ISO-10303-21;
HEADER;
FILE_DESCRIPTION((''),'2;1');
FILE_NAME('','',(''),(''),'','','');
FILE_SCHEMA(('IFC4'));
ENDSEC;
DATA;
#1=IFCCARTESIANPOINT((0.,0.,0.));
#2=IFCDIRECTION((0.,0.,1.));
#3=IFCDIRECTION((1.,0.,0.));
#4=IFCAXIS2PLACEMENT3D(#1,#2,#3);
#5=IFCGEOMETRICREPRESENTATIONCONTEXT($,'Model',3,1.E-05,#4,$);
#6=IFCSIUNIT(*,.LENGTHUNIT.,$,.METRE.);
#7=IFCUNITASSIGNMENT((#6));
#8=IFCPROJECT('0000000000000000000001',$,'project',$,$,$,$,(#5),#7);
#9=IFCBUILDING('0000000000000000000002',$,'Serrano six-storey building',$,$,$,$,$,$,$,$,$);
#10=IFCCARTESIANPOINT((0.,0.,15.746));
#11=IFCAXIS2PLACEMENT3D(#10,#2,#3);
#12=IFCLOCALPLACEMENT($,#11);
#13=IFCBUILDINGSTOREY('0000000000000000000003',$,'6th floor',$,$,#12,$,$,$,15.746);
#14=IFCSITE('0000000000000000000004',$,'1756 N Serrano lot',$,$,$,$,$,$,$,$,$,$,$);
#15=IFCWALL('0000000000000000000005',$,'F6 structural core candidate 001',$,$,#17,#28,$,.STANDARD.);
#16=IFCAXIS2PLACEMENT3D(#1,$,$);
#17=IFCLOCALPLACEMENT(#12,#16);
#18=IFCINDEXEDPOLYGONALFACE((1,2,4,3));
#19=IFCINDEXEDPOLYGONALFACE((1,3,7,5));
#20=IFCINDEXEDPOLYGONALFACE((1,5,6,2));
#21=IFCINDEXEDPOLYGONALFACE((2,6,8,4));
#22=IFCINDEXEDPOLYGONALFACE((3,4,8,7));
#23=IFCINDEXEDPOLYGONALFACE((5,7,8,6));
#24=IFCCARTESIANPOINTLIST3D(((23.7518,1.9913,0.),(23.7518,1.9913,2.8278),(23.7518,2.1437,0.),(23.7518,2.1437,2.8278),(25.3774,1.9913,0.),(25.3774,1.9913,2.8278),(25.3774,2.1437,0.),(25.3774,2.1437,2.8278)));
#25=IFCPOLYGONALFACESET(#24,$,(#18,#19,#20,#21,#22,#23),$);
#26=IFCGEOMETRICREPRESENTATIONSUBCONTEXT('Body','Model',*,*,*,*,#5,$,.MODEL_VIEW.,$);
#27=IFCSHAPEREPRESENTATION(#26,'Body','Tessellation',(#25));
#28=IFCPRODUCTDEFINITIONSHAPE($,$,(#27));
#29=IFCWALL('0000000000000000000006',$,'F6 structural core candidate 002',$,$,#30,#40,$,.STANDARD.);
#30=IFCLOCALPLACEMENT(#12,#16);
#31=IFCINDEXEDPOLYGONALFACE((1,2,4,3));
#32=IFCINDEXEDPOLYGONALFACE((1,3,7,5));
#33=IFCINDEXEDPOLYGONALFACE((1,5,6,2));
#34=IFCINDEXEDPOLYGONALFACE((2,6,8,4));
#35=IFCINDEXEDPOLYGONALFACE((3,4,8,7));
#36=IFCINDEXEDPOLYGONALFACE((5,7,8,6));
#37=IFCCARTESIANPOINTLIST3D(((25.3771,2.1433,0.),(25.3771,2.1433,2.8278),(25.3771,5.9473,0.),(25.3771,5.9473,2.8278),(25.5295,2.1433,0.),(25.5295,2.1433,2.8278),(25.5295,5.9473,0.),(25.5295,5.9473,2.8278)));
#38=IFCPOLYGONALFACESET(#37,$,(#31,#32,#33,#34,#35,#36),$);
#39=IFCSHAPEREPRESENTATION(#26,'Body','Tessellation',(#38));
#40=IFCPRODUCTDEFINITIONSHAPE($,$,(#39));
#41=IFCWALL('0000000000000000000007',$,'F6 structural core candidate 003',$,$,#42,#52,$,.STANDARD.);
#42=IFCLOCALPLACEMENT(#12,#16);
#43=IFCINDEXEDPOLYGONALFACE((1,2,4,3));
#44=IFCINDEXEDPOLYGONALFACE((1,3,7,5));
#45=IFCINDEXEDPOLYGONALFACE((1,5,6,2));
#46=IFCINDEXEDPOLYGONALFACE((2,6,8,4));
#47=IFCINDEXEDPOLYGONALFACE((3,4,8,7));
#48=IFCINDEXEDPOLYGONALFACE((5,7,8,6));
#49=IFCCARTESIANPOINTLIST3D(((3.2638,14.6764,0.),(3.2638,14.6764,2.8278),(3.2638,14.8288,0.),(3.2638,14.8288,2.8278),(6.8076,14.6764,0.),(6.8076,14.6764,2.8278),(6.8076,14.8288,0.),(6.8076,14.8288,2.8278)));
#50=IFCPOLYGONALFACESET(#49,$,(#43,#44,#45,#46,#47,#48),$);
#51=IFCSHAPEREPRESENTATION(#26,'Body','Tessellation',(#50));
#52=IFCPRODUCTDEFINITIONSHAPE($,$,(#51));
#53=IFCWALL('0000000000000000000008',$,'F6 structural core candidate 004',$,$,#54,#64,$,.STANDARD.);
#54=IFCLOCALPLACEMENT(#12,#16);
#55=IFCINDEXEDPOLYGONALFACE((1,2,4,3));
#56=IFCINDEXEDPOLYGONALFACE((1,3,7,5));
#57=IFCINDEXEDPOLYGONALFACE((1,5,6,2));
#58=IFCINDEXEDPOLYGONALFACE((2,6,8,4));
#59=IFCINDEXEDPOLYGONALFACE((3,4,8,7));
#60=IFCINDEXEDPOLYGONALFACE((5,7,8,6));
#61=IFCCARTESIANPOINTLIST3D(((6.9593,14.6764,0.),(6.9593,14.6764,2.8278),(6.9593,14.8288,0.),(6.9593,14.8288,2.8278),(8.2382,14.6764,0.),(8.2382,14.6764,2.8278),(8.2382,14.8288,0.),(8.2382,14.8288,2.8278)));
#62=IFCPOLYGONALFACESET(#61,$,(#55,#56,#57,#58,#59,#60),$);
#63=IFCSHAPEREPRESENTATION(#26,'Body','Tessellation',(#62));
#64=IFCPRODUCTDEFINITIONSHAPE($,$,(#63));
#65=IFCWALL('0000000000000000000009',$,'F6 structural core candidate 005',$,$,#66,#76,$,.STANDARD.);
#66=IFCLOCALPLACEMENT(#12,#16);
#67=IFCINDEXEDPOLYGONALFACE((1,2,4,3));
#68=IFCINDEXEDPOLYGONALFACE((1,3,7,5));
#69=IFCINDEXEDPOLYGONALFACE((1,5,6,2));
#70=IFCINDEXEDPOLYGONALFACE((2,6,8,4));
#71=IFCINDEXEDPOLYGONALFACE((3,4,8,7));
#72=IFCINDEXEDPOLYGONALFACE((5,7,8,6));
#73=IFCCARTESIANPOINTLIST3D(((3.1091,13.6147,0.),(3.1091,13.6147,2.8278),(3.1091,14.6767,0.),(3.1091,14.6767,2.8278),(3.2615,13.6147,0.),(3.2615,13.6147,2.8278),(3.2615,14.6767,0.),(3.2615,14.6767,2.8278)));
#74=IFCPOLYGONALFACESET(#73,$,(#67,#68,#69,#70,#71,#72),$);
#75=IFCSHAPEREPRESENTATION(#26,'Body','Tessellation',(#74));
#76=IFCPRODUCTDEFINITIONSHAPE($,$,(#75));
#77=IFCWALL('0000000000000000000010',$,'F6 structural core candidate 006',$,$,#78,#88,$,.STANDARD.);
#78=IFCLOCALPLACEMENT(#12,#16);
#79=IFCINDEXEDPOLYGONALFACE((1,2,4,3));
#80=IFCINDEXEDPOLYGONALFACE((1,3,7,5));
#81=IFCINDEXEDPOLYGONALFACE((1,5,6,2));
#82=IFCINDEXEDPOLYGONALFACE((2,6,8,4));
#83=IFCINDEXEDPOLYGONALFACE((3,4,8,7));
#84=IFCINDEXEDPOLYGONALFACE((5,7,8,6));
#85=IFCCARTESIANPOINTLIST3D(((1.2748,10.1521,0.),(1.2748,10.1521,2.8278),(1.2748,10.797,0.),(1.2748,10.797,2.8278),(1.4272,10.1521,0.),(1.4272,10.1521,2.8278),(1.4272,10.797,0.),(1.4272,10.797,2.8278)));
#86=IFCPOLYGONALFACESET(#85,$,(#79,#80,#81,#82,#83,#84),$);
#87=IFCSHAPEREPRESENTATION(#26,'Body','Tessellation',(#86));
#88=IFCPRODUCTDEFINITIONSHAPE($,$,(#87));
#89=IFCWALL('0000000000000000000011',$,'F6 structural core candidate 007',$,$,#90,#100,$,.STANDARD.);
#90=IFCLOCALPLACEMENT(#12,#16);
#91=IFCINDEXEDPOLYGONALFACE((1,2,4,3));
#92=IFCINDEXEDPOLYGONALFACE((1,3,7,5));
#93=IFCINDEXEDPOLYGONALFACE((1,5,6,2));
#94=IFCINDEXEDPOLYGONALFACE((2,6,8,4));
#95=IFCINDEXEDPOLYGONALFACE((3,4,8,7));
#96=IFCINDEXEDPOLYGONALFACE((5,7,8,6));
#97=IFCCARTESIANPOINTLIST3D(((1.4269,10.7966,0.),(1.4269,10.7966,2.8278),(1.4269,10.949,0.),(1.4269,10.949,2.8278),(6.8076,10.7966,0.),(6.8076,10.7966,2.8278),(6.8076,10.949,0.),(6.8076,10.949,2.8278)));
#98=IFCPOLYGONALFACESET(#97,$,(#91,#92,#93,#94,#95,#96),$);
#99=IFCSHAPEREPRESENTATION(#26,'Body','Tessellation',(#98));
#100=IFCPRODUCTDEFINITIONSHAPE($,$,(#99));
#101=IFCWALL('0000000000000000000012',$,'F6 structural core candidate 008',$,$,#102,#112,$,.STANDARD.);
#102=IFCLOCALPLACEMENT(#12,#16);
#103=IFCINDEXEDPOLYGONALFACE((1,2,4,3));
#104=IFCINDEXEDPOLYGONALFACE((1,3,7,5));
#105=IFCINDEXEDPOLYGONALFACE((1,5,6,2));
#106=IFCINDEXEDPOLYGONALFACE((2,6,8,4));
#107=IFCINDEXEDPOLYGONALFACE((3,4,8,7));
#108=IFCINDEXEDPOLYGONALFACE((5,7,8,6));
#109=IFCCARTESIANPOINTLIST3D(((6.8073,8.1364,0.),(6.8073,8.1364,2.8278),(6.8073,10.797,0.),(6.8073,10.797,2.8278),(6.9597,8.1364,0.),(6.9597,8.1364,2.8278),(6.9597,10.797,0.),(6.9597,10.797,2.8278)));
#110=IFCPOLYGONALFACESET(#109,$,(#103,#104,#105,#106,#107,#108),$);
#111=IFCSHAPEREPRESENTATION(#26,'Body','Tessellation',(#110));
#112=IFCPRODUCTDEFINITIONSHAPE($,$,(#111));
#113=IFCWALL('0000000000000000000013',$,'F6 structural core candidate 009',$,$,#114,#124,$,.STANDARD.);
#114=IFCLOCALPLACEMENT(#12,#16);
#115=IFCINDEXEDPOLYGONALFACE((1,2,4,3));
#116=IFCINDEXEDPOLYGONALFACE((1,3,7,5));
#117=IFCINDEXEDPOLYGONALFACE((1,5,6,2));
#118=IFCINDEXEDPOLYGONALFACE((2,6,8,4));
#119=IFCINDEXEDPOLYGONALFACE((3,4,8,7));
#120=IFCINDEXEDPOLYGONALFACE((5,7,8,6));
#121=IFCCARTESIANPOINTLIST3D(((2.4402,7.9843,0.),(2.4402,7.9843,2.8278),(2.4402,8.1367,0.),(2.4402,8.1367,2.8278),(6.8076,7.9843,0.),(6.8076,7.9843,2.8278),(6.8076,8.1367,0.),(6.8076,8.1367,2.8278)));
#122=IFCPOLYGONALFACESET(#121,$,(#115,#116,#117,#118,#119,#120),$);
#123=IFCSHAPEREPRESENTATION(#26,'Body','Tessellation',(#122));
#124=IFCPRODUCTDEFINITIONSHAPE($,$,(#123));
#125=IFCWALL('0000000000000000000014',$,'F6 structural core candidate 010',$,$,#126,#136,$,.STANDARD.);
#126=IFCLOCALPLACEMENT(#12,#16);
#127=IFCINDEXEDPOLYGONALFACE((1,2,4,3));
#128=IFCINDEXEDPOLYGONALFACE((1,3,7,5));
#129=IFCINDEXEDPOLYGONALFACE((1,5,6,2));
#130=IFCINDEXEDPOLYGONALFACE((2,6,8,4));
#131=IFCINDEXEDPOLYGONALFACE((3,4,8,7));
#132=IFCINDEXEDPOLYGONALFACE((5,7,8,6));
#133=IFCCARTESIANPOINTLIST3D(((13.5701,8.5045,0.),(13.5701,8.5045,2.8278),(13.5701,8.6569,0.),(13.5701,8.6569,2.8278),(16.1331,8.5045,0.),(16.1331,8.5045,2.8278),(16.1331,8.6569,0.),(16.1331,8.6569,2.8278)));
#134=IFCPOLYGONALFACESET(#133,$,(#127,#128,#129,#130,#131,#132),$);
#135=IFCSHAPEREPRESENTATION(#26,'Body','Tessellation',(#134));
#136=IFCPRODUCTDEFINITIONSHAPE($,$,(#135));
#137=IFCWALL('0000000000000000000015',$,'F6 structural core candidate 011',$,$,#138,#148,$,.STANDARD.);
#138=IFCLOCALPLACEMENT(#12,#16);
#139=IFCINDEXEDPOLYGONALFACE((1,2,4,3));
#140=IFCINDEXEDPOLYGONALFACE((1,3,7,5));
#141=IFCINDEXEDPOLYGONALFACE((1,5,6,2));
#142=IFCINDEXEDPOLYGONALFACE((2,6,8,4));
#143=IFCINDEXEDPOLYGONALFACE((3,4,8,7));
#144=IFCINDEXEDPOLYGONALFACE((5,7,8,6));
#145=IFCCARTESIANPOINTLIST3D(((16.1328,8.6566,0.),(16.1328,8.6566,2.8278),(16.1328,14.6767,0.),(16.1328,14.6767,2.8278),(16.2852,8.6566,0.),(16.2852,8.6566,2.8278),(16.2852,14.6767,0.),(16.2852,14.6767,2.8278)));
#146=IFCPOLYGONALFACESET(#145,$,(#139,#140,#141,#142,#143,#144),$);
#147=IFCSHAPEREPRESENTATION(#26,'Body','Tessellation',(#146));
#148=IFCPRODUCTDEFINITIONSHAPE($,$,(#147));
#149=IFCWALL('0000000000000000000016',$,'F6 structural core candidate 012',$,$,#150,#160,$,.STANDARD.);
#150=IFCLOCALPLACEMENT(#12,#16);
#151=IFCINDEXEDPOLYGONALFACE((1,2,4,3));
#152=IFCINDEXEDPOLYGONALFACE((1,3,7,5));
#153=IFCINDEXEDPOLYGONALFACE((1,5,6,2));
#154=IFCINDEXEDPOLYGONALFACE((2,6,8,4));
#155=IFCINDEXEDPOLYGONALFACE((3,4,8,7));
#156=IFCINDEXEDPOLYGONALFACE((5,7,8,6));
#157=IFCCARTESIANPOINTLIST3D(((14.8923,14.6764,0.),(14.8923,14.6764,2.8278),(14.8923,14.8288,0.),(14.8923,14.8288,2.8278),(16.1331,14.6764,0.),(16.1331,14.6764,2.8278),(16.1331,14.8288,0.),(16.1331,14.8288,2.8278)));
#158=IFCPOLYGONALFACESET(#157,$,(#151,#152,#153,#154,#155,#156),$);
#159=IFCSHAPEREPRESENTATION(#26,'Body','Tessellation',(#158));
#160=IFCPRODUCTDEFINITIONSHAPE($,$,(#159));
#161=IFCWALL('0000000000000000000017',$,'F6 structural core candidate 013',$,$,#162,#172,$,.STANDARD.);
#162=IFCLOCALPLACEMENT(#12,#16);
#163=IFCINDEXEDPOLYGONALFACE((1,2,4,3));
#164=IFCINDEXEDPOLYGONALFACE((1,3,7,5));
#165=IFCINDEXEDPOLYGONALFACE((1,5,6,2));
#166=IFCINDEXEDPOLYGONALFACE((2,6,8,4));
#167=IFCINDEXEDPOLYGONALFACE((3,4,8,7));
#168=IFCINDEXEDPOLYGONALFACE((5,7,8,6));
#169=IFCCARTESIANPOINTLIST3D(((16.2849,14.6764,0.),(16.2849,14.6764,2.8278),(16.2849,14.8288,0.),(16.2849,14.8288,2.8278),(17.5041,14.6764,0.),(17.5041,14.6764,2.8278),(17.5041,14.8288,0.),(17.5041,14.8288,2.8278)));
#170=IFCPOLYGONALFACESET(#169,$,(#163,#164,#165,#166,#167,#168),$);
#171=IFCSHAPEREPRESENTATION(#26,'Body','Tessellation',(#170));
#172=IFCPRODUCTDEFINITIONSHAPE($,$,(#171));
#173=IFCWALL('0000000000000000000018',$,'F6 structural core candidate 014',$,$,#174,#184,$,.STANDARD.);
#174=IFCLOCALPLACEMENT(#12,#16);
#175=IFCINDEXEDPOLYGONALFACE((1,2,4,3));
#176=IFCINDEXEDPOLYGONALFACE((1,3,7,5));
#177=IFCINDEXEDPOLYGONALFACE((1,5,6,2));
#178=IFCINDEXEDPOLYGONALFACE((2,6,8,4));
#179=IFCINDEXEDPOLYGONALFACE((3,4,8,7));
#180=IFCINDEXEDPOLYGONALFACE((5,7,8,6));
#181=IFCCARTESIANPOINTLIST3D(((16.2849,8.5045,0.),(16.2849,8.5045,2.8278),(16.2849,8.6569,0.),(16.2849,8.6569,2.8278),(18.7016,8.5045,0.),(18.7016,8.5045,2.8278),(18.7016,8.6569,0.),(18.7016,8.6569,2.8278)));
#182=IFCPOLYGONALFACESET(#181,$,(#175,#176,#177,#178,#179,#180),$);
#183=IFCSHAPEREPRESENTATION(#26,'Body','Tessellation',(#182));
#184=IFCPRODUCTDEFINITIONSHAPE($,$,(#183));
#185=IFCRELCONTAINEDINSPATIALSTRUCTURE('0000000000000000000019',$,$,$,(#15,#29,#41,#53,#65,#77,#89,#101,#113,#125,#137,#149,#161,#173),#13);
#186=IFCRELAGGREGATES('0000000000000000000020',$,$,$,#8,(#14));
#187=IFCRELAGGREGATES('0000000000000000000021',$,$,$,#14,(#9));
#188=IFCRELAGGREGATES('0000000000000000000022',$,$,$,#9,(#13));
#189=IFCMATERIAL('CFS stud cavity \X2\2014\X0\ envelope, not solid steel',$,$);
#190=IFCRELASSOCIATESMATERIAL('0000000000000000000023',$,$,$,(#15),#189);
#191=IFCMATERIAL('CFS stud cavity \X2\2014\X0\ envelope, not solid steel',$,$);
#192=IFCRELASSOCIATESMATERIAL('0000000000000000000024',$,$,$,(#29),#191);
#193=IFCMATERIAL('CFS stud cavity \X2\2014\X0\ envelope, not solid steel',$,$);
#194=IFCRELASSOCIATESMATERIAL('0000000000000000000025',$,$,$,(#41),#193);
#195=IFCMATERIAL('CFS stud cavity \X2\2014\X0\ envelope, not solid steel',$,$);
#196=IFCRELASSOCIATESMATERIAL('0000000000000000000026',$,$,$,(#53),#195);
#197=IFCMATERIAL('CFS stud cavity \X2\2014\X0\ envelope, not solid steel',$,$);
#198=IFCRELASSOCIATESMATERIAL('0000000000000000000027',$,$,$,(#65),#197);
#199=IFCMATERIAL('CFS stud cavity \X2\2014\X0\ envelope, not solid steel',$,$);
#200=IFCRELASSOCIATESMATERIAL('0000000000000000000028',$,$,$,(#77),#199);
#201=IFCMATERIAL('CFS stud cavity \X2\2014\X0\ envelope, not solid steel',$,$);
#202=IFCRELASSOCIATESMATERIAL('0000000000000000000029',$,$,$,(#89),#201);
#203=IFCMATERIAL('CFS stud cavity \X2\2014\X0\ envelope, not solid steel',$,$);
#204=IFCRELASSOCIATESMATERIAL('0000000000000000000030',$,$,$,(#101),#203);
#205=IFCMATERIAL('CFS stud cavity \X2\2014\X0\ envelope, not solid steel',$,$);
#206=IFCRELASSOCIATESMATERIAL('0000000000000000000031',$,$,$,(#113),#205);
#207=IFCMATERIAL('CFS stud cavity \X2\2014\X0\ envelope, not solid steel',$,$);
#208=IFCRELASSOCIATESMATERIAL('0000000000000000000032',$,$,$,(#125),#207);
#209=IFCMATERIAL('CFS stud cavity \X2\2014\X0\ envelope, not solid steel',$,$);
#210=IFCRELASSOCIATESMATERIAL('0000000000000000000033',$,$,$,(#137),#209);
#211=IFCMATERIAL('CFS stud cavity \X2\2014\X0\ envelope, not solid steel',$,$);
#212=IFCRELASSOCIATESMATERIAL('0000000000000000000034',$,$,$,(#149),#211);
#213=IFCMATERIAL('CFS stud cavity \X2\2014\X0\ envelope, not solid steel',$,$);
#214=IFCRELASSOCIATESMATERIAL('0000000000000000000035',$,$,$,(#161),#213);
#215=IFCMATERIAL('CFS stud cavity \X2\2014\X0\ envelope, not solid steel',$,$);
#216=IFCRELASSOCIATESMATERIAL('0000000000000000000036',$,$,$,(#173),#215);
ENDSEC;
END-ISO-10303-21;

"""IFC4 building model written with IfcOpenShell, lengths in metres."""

from ifc_helpers import new_model, si_unit, frame, origin_with_axes, place, context, subcontext, project, spatial, polyline, outline, extrude, material, element, save


model = new_model("IFC4")

# Units and contexts
model_context = context("Model", 3, precision=1e-05, world=origin_with_axes())
body_context = subcontext(model_context, "Body", "Model", "MODEL_VIEW")
ifc_project = project(units=[si_unit("LENGTHUNIT", "METRE")], contexts=[model_context])

# Site, building, storey
site = spatial("IfcSite", under=ifc_project, Name="1756 N Serrano lot")
building = spatial("IfcBuilding", under=site, Name="Serrano six-storey building")
storey_placement = place(None, frame((0.0, 0.0, 15.746), z_axis=(0.0, 0.0, 1.0), x_axis=(1.0, 0.0, 0.0)))
storey = spatial("IfcBuildingStorey", under=building, at=storey_placement, Name="6th floor", Elevation=15.746)

# Walls
ifc_material_1 = material(Name="CFS stud cavity — envelope, not solid steel")
wall_1_placement = place(storey_placement, frame((0.0, 0.0, -15.746), z_axis=(0.0, 0.0, 1.0), x_axis=(1.0, 0.0, 0.0)))
element("IfcWall", 1, at=wall_1_placement, inside=storey, material=ifc_material_1, Name="F6 structural core candidate 001", PredefinedType="STANDARD", context=body_context, shape_type="SweptSolid", body=[
    extrude(outline(polyline([(25.3774, 2.1437), (25.3774, 1.9913), (23.7518, 1.9913), (23.7518, 2.1437), (25.3774, 2.1437)])), frame((0.0, 0.0, 15.746)), (0.0, 0.0, 1.0), 2.8278),
])
ifc_material_2 = material(Name="CFS stud cavity — envelope, not solid steel")
wall_2_placement = place(storey_placement, frame((0.0, 0.0, -15.746), z_axis=(0.0, 0.0, 1.0), x_axis=(1.0, 0.0, 0.0)))
element("IfcWall", 2, at=wall_2_placement, inside=storey, material=ifc_material_2, Name="F6 structural core candidate 002", PredefinedType="STANDARD", context=body_context, shape_type="SweptSolid", body=[
    extrude(outline(polyline([(25.5295, 2.1433), (25.3771, 2.1433), (25.3771, 5.9473), (25.5295, 5.9473), (25.5295, 2.1433)])), frame((0.0, 0.0, 15.746)), (0.0, 0.0, 1.0), 2.8278),
])
ifc_material_3 = material(Name="CFS stud cavity — envelope, not solid steel")
wall_3_placement = place(storey_placement, frame((0.0, 0.0, -15.746), z_axis=(0.0, 0.0, 1.0), x_axis=(1.0, 0.0, 0.0)))
element("IfcWall", 3, at=wall_3_placement, inside=storey, material=ifc_material_3, Name="F6 structural core candidate 003", PredefinedType="STANDARD", context=body_context, shape_type="SweptSolid", body=[
    extrude(outline(polyline([(6.8076, 14.8288), (6.8076, 14.6764), (3.2638, 14.6764), (3.2638, 14.8288), (6.8076, 14.8288)])), frame((0.0, 0.0, 15.746)), (0.0, 0.0, 1.0), 2.8278),
])
ifc_material_4 = material(Name="CFS stud cavity — envelope, not solid steel")
wall_4_placement = place(storey_placement, frame((0.0, 0.0, -15.746), z_axis=(0.0, 0.0, 1.0), x_axis=(1.0, 0.0, 0.0)))
element("IfcWall", 4, at=wall_4_placement, inside=storey, material=ifc_material_4, Name="F6 structural core candidate 004", PredefinedType="STANDARD", context=body_context, shape_type="SweptSolid", body=[
    extrude(outline(polyline([(8.2382, 14.8288), (8.2382, 14.6764), (6.9593, 14.6764), (6.9593, 14.8288), (8.2382, 14.8288)])), frame((0.0, 0.0, 15.746)), (0.0, 0.0, 1.0), 2.8278),
])
ifc_material_5 = material(Name="CFS stud cavity — envelope, not solid steel")
wall_5_placement = place(storey_placement, frame((0.0, 0.0, -15.746), z_axis=(0.0, 0.0, 1.0), x_axis=(1.0, 0.0, 0.0)))
element("IfcWall", 5, at=wall_5_placement, inside=storey, material=ifc_material_5, Name="F6 structural core candidate 005", PredefinedType="STANDARD", context=body_context, shape_type="SweptSolid", body=[
    extrude(outline(polyline([(3.2615, 13.6147), (3.1091, 13.6147), (3.1091, 14.6767), (3.2615, 14.6767), (3.2615, 13.6147)])), frame((0.0, 0.0, 15.746)), (0.0, 0.0, 1.0), 2.8278),
])
ifc_material_6 = material(Name="CFS stud cavity — envelope, not solid steel")
wall_6_placement = place(storey_placement, frame((0.0, 0.0, -15.746), z_axis=(0.0, 0.0, 1.0), x_axis=(1.0, 0.0, 0.0)))
element("IfcWall", 6, at=wall_6_placement, inside=storey, material=ifc_material_6, Name="F6 structural core candidate 006", PredefinedType="STANDARD", context=body_context, shape_type="SweptSolid", body=[
    extrude(outline(polyline([(1.4272, 10.1521), (1.2748, 10.1521), (1.2748, 10.797), (1.4272, 10.797), (1.4272, 10.1521)])), frame((0.0, 0.0, 15.746)), (0.0, 0.0, 1.0), 2.8278),
])
ifc_material_7 = material(Name="CFS stud cavity — envelope, not solid steel")
wall_7_placement = place(storey_placement, frame((0.0, 0.0, -15.746), z_axis=(0.0, 0.0, 1.0), x_axis=(1.0, 0.0, 0.0)))
element("IfcWall", 7, at=wall_7_placement, inside=storey, material=ifc_material_7, Name="F6 structural core candidate 007", PredefinedType="STANDARD", context=body_context, shape_type="SweptSolid", body=[
    extrude(outline(polyline([(6.8076, 10.949), (6.8076, 10.7966), (1.4269, 10.7966), (1.4269, 10.949), (6.8076, 10.949)])), frame((0.0, 0.0, 15.746)), (0.0, 0.0, 1.0), 2.8278),
])
ifc_material_8 = material(Name="CFS stud cavity — envelope, not solid steel")
wall_8_placement = place(storey_placement, frame((0.0, 0.0, -15.746), z_axis=(0.0, 0.0, 1.0), x_axis=(1.0, 0.0, 0.0)))
element("IfcWall", 8, at=wall_8_placement, inside=storey, material=ifc_material_8, Name="F6 structural core candidate 008", PredefinedType="STANDARD", context=body_context, shape_type="SweptSolid", body=[
    extrude(outline(polyline([(6.9597, 8.1364), (6.8073, 8.1364), (6.8073, 10.797), (6.9597, 10.797), (6.9597, 8.1364)])), frame((0.0, 0.0, 15.746)), (0.0, 0.0, 1.0), 2.8278),
])
ifc_material_9 = material(Name="CFS stud cavity — envelope, not solid steel")
wall_9_placement = place(storey_placement, frame((0.0, 0.0, -15.746), z_axis=(0.0, 0.0, 1.0), x_axis=(1.0, 0.0, 0.0)))
element("IfcWall", 9, at=wall_9_placement, inside=storey, material=ifc_material_9, Name="F6 structural core candidate 009", PredefinedType="STANDARD", context=body_context, shape_type="SweptSolid", body=[
    extrude(outline(polyline([(6.8076, 8.1367), (6.8076, 7.9843), (2.4402, 7.9843), (2.4402, 8.1367), (6.8076, 8.1367)])), frame((0.0, 0.0, 15.746)), (0.0, 0.0, 1.0), 2.8278),
])
ifc_material_10 = material(Name="CFS stud cavity — envelope, not solid steel")
wall_10_placement = place(storey_placement, frame((0.0, 0.0, -15.746), z_axis=(0.0, 0.0, 1.0), x_axis=(1.0, 0.0, 0.0)))
element("IfcWall", 10, at=wall_10_placement, inside=storey, material=ifc_material_10, Name="F6 structural core candidate 010", PredefinedType="STANDARD", context=body_context, shape_type="SweptSolid", body=[
    extrude(outline(polyline([(16.1331, 8.6569), (16.1331, 8.5045), (13.5701, 8.5045), (13.5701, 8.6569), (16.1331, 8.6569)])), frame((0.0, 0.0, 15.746)), (0.0, 0.0, 1.0), 2.8278),
])
ifc_material_11 = material(Name="CFS stud cavity — envelope, not solid steel")
wall_11_placement = place(storey_placement, frame((0.0, 0.0, -15.746), z_axis=(0.0, 0.0, 1.0), x_axis=(1.0, 0.0, 0.0)))
element("IfcWall", 11, at=wall_11_placement, inside=storey, material=ifc_material_11, Name="F6 structural core candidate 011", PredefinedType="STANDARD", context=body_context, shape_type="SweptSolid", body=[
    extrude(outline(polyline([(16.2852, 8.6566), (16.1328, 8.6566), (16.1328, 14.6767), (16.2852, 14.6767), (16.2852, 8.6566)])), frame((0.0, 0.0, 15.746)), (0.0, 0.0, 1.0), 2.8278),
])
ifc_material_12 = material(Name="CFS stud cavity — envelope, not solid steel")
wall_12_placement = place(storey_placement, frame((0.0, 0.0, -15.746), z_axis=(0.0, 0.0, 1.0), x_axis=(1.0, 0.0, 0.0)))
element("IfcWall", 12, at=wall_12_placement, inside=storey, material=ifc_material_12, Name="F6 structural core candidate 012", PredefinedType="STANDARD", context=body_context, shape_type="SweptSolid", body=[
    extrude(outline(polyline([(16.1331, 14.8288), (16.1331, 14.6764), (14.8923, 14.6764), (14.8923, 14.8288), (16.1331, 14.8288)])), frame((0.0, 0.0, 15.746)), (0.0, 0.0, 1.0), 2.8278),
])
ifc_material_13 = material(Name="CFS stud cavity — envelope, not solid steel")
wall_13_placement = place(storey_placement, frame((0.0, 0.0, -15.746), z_axis=(0.0, 0.0, 1.0), x_axis=(1.0, 0.0, 0.0)))
element("IfcWall", 13, at=wall_13_placement, inside=storey, material=ifc_material_13, Name="F6 structural core candidate 013", PredefinedType="STANDARD", context=body_context, shape_type="SweptSolid", body=[
    extrude(outline(polyline([(17.5041, 14.8288), (17.5041, 14.6764), (16.2849, 14.6764), (16.2849, 14.8288), (17.5041, 14.8288)])), frame((0.0, 0.0, 15.746)), (0.0, 0.0, 1.0), 2.8278),
])
ifc_material_14 = material(Name="CFS stud cavity — envelope, not solid steel")
wall_14_placement = place(storey_placement, frame((0.0, 0.0, -15.746), z_axis=(0.0, 0.0, 1.0), x_axis=(1.0, 0.0, 0.0)))
element("IfcWall", 14, at=wall_14_placement, inside=storey, material=ifc_material_14, Name="F6 structural core candidate 014", PredefinedType="STANDARD", context=body_context, shape_type="SweptSolid", body=[
    extrude(outline(polyline([(18.7016, 8.6569), (18.7016, 8.5045), (16.2849, 8.5045), (16.2849, 8.6569), (18.7016, 8.6569)])), frame((0.0, 0.0, 15.746)), (0.0, 0.0, 1.0), 2.8278),
])

save(model, "model.ifc")
